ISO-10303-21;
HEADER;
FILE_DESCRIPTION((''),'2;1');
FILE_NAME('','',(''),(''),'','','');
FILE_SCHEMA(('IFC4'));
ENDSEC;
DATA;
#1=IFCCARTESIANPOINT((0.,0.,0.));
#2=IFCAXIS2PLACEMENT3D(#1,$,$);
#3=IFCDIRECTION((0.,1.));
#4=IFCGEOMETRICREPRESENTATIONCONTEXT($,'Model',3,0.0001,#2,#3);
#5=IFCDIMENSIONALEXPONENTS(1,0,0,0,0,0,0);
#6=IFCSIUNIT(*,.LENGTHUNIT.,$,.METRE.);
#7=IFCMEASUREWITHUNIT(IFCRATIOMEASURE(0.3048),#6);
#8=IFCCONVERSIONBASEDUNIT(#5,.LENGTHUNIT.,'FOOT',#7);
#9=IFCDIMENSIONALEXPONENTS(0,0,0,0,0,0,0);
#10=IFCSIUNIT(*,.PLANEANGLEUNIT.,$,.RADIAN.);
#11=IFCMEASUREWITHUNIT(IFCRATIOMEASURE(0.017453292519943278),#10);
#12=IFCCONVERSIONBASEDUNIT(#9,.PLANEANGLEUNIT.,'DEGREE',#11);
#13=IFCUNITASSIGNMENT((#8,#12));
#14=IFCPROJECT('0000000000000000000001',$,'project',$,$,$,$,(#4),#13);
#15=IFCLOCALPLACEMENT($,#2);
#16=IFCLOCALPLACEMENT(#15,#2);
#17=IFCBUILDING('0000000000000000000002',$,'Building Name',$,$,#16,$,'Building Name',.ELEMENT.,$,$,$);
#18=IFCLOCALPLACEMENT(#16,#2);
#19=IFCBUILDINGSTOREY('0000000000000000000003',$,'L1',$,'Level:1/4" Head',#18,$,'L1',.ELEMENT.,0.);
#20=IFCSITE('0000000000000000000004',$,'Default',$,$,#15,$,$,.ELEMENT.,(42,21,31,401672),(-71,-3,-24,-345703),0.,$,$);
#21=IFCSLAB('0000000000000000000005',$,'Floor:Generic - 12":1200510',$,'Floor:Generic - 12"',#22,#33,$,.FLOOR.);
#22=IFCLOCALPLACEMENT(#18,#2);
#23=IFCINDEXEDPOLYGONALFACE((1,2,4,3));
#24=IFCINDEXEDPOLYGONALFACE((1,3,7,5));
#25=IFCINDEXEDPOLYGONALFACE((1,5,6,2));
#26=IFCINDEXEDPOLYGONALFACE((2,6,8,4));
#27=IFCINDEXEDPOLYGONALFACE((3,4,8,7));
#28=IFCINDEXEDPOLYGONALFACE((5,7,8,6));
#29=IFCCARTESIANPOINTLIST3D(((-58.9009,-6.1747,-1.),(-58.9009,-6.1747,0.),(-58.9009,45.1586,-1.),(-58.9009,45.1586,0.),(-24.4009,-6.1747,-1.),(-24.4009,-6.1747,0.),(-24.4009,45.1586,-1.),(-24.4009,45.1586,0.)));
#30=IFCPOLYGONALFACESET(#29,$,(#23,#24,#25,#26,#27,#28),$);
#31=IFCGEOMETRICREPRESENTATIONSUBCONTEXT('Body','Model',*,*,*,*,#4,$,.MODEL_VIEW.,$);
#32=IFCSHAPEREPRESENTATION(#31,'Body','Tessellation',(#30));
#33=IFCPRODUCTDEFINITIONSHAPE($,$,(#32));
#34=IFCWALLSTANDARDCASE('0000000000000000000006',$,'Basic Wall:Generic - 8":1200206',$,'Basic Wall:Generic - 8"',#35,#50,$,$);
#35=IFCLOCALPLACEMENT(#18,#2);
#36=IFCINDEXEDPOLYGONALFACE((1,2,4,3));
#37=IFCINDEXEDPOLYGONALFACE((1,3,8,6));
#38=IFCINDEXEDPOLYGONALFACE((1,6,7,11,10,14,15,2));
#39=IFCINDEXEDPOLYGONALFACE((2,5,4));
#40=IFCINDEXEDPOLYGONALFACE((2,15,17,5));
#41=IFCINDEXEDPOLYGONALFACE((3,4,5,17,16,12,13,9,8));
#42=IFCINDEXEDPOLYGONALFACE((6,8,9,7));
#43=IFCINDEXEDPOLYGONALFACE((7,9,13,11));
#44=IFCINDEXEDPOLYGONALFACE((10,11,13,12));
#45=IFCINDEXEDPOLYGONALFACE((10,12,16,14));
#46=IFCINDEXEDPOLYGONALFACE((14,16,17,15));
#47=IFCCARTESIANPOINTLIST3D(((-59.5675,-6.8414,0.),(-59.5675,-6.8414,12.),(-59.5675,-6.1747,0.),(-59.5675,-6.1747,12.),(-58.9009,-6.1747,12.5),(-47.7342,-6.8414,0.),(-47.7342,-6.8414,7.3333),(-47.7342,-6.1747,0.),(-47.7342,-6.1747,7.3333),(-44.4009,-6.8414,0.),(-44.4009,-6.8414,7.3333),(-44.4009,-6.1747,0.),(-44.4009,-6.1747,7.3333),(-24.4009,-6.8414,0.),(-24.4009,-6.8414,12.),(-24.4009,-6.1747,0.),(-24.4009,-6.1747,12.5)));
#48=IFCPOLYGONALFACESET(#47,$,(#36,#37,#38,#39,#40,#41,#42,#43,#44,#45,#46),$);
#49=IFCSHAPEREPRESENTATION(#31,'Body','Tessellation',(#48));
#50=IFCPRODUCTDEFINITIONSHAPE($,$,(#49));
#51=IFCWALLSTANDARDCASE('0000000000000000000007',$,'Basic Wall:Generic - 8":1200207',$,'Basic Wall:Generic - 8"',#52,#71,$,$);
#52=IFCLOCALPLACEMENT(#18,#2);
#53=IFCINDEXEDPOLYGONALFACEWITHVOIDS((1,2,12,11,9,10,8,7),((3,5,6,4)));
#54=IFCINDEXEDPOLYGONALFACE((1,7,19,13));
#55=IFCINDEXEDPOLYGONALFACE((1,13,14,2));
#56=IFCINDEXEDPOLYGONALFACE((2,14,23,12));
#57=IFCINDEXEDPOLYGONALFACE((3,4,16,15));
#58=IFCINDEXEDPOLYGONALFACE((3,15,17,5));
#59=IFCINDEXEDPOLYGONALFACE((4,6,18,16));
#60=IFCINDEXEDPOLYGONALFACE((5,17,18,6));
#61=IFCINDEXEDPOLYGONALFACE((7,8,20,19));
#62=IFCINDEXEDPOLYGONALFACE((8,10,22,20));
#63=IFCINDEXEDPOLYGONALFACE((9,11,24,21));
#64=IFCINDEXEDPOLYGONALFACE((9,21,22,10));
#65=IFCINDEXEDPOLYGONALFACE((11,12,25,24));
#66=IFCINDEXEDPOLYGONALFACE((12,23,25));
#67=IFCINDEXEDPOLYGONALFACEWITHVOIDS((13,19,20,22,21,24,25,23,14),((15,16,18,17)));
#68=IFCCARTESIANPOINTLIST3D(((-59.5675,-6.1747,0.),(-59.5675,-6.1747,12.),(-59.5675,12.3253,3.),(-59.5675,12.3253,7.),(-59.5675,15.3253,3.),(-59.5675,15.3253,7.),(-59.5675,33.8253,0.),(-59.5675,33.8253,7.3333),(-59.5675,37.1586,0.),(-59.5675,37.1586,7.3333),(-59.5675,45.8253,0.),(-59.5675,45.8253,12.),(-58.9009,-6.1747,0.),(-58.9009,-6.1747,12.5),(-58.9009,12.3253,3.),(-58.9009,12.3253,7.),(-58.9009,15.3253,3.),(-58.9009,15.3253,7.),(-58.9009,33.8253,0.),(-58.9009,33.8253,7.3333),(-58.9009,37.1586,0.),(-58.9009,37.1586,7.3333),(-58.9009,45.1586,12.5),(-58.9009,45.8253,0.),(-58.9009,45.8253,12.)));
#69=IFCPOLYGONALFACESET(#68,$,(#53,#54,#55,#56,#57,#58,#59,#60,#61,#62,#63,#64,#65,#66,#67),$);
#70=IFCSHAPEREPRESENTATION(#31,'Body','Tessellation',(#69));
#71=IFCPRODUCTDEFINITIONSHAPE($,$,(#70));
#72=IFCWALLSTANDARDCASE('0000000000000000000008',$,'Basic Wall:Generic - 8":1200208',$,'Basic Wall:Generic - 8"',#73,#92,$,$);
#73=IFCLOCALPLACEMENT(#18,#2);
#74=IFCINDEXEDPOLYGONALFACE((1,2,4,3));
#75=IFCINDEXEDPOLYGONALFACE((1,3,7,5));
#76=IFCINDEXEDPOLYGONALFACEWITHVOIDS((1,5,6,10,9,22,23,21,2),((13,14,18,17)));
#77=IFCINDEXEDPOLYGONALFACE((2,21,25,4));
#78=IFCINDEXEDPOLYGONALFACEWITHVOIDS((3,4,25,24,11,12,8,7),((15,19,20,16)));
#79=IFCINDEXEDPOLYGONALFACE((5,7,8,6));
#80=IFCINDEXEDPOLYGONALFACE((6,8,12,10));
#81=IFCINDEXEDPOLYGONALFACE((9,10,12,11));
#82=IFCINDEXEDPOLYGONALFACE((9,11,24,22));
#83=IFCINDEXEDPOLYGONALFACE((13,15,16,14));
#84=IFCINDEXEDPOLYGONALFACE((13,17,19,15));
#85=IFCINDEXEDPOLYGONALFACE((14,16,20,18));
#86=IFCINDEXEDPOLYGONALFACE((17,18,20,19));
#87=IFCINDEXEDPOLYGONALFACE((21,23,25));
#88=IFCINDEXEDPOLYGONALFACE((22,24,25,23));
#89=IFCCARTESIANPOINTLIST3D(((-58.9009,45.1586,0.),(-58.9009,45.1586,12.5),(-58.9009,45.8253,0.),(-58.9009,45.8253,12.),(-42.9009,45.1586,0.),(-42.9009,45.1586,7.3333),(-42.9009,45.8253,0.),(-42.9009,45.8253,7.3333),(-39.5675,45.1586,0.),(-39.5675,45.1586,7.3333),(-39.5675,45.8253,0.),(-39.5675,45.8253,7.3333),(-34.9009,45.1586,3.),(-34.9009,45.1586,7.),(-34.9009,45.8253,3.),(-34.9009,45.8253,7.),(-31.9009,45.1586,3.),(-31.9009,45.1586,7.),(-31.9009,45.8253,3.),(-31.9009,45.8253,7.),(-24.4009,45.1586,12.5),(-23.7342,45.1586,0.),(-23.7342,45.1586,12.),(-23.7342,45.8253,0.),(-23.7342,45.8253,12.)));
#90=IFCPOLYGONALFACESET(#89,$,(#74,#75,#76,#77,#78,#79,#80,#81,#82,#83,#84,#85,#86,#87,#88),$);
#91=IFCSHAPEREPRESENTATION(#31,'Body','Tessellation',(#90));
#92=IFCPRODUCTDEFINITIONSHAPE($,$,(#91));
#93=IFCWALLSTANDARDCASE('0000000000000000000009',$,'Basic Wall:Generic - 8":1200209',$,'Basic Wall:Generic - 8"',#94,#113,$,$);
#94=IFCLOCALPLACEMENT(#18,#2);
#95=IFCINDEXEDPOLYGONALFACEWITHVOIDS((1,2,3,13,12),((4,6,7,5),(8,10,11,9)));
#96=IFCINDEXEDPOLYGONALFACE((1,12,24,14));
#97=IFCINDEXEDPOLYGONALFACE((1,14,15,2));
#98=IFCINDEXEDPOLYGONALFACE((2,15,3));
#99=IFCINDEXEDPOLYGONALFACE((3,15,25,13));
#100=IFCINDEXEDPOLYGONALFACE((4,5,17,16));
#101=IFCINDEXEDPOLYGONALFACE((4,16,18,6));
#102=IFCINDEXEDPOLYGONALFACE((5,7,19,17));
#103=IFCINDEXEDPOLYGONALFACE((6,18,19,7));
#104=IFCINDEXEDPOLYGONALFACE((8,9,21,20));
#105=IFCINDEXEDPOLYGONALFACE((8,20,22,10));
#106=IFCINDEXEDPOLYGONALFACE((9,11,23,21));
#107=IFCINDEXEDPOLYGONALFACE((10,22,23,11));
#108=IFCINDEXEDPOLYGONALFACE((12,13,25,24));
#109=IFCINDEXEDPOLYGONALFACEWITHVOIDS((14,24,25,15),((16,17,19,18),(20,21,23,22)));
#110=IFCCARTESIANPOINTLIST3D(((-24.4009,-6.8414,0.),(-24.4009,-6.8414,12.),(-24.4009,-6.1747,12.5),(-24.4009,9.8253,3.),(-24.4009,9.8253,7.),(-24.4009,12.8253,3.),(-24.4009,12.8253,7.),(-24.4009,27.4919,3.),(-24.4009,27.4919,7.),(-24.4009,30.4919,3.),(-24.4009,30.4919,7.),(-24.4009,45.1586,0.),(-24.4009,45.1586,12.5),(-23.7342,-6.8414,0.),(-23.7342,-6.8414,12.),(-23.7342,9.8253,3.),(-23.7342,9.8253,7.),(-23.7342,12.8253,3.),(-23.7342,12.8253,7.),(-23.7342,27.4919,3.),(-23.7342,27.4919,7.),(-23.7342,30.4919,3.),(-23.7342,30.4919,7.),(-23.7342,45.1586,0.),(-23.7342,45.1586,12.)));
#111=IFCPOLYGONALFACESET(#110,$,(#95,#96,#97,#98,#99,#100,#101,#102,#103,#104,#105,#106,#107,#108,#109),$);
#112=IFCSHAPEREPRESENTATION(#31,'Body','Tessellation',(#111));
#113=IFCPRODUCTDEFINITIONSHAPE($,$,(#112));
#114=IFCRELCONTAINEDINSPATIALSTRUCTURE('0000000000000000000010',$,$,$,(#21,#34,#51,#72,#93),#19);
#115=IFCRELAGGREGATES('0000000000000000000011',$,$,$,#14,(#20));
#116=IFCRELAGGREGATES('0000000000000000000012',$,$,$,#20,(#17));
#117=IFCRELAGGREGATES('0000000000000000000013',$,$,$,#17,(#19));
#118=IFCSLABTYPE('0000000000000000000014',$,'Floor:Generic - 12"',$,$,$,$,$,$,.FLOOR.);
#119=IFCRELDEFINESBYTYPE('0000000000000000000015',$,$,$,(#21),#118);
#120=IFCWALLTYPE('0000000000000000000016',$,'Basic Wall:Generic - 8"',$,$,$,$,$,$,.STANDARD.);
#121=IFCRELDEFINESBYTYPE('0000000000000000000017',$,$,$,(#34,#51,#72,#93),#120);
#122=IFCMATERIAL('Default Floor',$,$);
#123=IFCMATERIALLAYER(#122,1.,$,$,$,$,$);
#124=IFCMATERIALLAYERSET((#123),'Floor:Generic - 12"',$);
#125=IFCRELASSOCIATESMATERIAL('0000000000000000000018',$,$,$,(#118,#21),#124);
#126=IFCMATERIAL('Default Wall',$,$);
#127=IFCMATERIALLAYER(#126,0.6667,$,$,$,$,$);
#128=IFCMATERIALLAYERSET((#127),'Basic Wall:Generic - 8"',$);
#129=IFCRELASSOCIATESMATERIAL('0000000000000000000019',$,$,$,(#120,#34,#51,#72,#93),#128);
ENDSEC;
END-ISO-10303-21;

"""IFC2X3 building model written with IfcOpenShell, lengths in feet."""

from ifc_helpers import new_model, entity, si_unit, converted_unit, direction, frame, frame_2d, origin, place, context, subcontext, project, spatial, polyline, rectangle, extrude, clip, bounded_halfspace, material, layer, layer_set, layer_usage, type_object, element, save


model = new_model("IFC2X3")

# Units and contexts
model_context = context("Model", 3, precision=0.0001, world=origin(), true_north=direction((0.0, 1.0)))
body_context = subcontext(model_context, "Body", "Model", "MODEL_VIEW")
ifc_project = project(units=[converted_unit("LENGTHUNIT", "FOOT", entity("IfcRatioMeasure", 0.3048), si_unit("LENGTHUNIT", "METRE"), dimensions=[1, 0, 0, 0, 0, 0, 0]), converted_unit("PLANEANGLEUNIT", "DEGREE", entity("IfcRatioMeasure", 0.017453292519943278), si_unit("PLANEANGLEUNIT", "RADIAN"), dimensions=[0, 0, 0, 0, 0, 0, 0])], contexts=[model_context])

# Site, building, storey
site_placement = place(None, origin())
site = spatial("IfcSite", under=ifc_project, at=site_placement, Name="Default", CompositionType="ELEMENT", RefLatitude=(42, 21, 31, 401672), RefLongitude=(-71, -3, -24, -345703), RefElevation=0.0)
building_placement = place(site_placement, origin())
building = spatial("IfcBuilding", under=site, at=building_placement, Name="Building Name", LongName="Building Name", CompositionType="ELEMENT")
storey_placement = place(building_placement, origin())
storey = spatial("IfcBuildingStorey", under=building, at=storey_placement, Name="L1", ObjectType="Level:1/4\" Head", LongName="L1", CompositionType="ELEMENT", Elevation=0.0)

# Slab
ifc_material_1 = material(Name="Default Floor")
ifc_layer_1 = layer(ifc_material_1, 1.0)
ifc_layer_set_1 = layer_set([ifc_layer_1], Name="Floor:Generic - 12\"")
ifc_layer_usage_1 = layer_usage(ifc_layer_set_1, "AXIS3", "POSITIVE", 0.0)
slab_type = type_object("IfcSlabType", Name="Floor:Generic - 12\"", PredefinedType="FLOOR", material=ifc_layer_set_1)
slab_placement = place(storey_placement, origin())
element("IfcSlab", 1, at=slab_placement, inside=storey, type_object=slab_type, material=ifc_layer_usage_1, Name="Floor:Generic - 12\":1200510", ObjectType="Floor:Generic - 12\"", PredefinedType="FLOOR", context=body_context, shape_type="SweptSolid", body=[
    extrude(rectangle(XDim=51.3333, YDim=34.5, at=frame_2d((0.0, 0.0), x_axis=(1.0, 0.0))), frame((-41.6509, 19.4919, 0.0), z_axis=(0.0, 0.0, -1.0), x_axis=(0.0, 1.0, 0.0)), (0.0, 0.0, 1.0), 1.0),
])

# Wall, opening
ifc_material_2 = material(Name="Default Wall")
ifc_layer_2 = layer(ifc_material_2, 0.6667)
ifc_layer_set_2 = layer_set([ifc_layer_2], Name="Basic Wall:Generic - 8\"")
ifc_layer_usage_2 = layer_usage(ifc_layer_set_2, "AXIS2", "NEGATIVE", 0.3333)
wall_type = type_object("IfcWallType", Name="Basic Wall:Generic - 8\"", PredefinedType="STANDARD", material=ifc_layer_set_2)
wall_1_placement = place(storey_placement, frame((-59.5675, -6.5081, 0.0)))
wall_1 = element("IfcWallStandardCase", 2, at=wall_1_placement, inside=storey, type_object=wall_type, material=ifc_layer_usage_2, Name="Basic Wall:Generic - 8\":1200206", ObjectType="Basic Wall:Generic - 8\"", context=body_context, shape_type="Clipping", body=[
    clip(clip(extrude(rectangle(XDim=0.6667, YDim=35.1667, at=frame_2d((17.5833, 0.0), x_axis=(0.0, 1.0))), origin(), (0.0, 0.0, 1.0), 12.5), bounded_halfspace(frame((0.0, 0.3333, 12.0), z_axis=(-0.6, 0.0, 0.8), x_axis=(0.0, -1.0, 0.0)), False, frame((0.0, 0.3333, 12.0)), polyline([(0.0, 0.0), (0.0, -0.6667), (0.6667, 0.0), (0.0, 0.0)]))), bounded_halfspace(frame((0.0, -0.3333, 12.0), z_axis=(0.0, -0.6, 0.8), x_axis=(1.0, 0.0, 0.0)), False, frame((0.0, -0.3333, 12.0)), polyline([(0.0, 0.0), (35.1667, 0.0), (35.1667, 0.6667), (0.6667, 0.6667), (0.0, 0.0)]))),
])
opening_1_placement = place(wall_1_placement, frame((15.1667, 0.3333, 0.0)))
element("IfcOpeningElement", 3, at=opening_1_placement, cuts=wall_1, ObjectType="Opening", context=body_context, shape_type="SweptSolid", body=[
    extrude(rectangle(XDim=7.3333, YDim=3.3333, at=frame_2d((3.6667, 1.6667), x_axis=(1.0, 0.0))), frame((0.0, 0.0, 0.0), z_axis=(0.0, -1.0, 0.0), x_axis=(0.0, 0.0, 1.0)), (0.0, 0.0, 1.0), 0.6667),
])

# Walls, openings
wall_2_placement = place(storey_placement, frame((-59.2342, 45.8253, 0.0), z_axis=(0.0, 0.0, 1.0), x_axis=(0.0, -1.0, 0.0)))
wall_2 = element("IfcWallStandardCase", 4, at=wall_2_placement, inside=storey, type_object=wall_type, material=ifc_layer_usage_2, Name="Basic Wall:Generic - 8\":1200207", ObjectType="Basic Wall:Generic - 8\"", context=body_context, shape_type="Clipping", body=[
    clip(clip(extrude(rectangle(XDim=52.0, YDim=0.6667, at=frame_2d((26.0, 0.0), x_axis=(-1.0, 0.0))), origin(), (0.0, 0.0, 1.0), 12.5), bounded_halfspace(frame((0.0, -0.3333, 12.0), z_axis=(0.0, -0.6, 0.8), x_axis=(1.0, 0.0, 0.0)), False, frame((0.0, -0.3333, 12.0)), polyline([(0.0, 0.0), (52.0, 0.0), (52.0, 0.6667), (0.6667, 0.6667), (0.0, 0.0)]))), bounded_halfspace(frame((0.0, 0.3333, 12.0), z_axis=(-0.6, 0.0, 0.8), x_axis=(0.0, -1.0, 0.0)), False, frame((0.0, 0.3333, 12.0)), polyline([(0.0, 0.0), (0.0, -0.6667), (0.6667, 0.0), (0.0, 0.0)]))),
])
opening_2_placement = place(wall_2_placement, frame((8.6667, -0.3333, 0.0)))
element("IfcOpeningElement", 5, at=opening_2_placement, cuts=wall_2, ObjectType="Opening", context=body_context, shape_type="SweptSolid", body=[
    extrude(rectangle(XDim=7.3333, YDim=3.3333, at=frame_2d((3.6667, 1.6667), x_axis=(1.0, 0.0))), frame((0.0, 0.0, 0.0), z_axis=(0.0, 1.0, 0.0), x_axis=(0.0, 0.0, 1.0)), (0.0, 0.0, 1.0), 0.6667),
])
opening_3_placement = place(wall_2_placement, frame((30.5, -0.3333, 3.0)))
element("IfcOpeningElement", 6, at=opening_3_placement, cuts=wall_2, ObjectType="Opening", context=body_context, shape_type="SweptSolid", body=[
    extrude(rectangle(XDim=4.0, YDim=3.0, at=frame_2d((2.0, 1.5), x_axis=(-1.0, 0.0))), frame((0.0, 0.0, 0.0), z_axis=(0.0, 1.0, 0.0), x_axis=(0.0, 0.0, 1.0)), (0.0, 0.0, 1.0), 0.6667),
])
wall_3_placement = place(storey_placement, frame((-23.7342, 45.4919, 0.0), z_axis=(0.0, 0.0, 1.0), x_axis=(-1.0, 0.0, 0.0)))
wall_3 = element("IfcWallStandardCase", 7, at=wall_3_placement, inside=storey, type_object=wall_type, material=ifc_layer_usage_2, Name="Basic Wall:Generic - 8\":1200208", ObjectType="Basic Wall:Generic - 8\"", context=body_context, shape_type="Clipping", body=[
    clip(clip(extrude(rectangle(XDim=35.1667, YDim=0.6667, at=frame_2d((17.5833, 0.0), x_axis=(-1.0, 0.0))), origin(), (0.0, 0.0, 1.0), 12.5), bounded_halfspace(frame((0.0, 0.3333, 12.0), z_axis=(-0.6, 0.0, 0.8), x_axis=(0.0, -1.0, 0.0)), False, frame((0.0, 0.3333, 12.0)), polyline([(0.0, 0.0), (0.0, -0.6667), (0.6667, 0.0), (0.0, 0.0)]))), bounded_halfspace(frame((0.0, -0.3333, 12.0), z_axis=(0.0, -0.6, 0.8), x_axis=(1.0, 0.0, 0.0)), False, frame((0.0, -0.3333, 12.0)), polyline([(0.0, 0.0), (35.1667, 0.0), (35.1667, 0.6667), (0.6667, 0.6667), (0.0, 0.0)]))),
])
opening_4_placement = place(wall_3_placement, frame((15.8333, -0.3333, 0.0)))
element("IfcOpeningElement", 8, at=opening_4_placement, cuts=wall_3, ObjectType="Opening", context=body_context, shape_type="SweptSolid", body=[
    extrude(rectangle(XDim=7.3333, YDim=3.3333, at=frame_2d((3.6667, 1.6667), x_axis=(1.0, 0.0))), frame((0.0, 0.0, 0.0), z_axis=(0.0, 1.0, 0.0), x_axis=(0.0, 0.0, 1.0)), (0.0, 0.0, 1.0), 0.6667),
])
opening_5_placement = place(wall_3_placement, frame((8.1667, -0.3333, 3.0)))
element("IfcOpeningElement", 9, at=opening_5_placement, cuts=wall_3, ObjectType="Opening", context=body_context, shape_type="SweptSolid", body=[
    extrude(rectangle(XDim=4.0, YDim=3.0, at=frame_2d((2.0, 1.5), x_axis=(-1.0, 0.0))), frame((0.0, 0.0, 0.0), z_axis=(0.0, 1.0, 0.0), x_axis=(0.0, 0.0, 1.0)), (0.0, 0.0, 1.0), 0.6667),
])
wall_4_placement = place(storey_placement, frame((-24.0675, -6.8414, 0.0), z_axis=(0.0, 0.0, 1.0), x_axis=(0.0, 1.0, 0.0)))
wall_4 = element("IfcWallStandardCase", 10, at=wall_4_placement, inside=storey, type_object=wall_type, material=ifc_layer_usage_2, Name="Basic Wall:Generic - 8\":1200209", ObjectType="Basic Wall:Generic - 8\"", context=body_context, shape_type="Clipping", body=[
    clip(clip(extrude(rectangle(XDim=52.0, YDim=0.6667, at=frame_2d((26.0, 0.0), x_axis=(-1.0, 0.0))), origin(), (0.0, 0.0, 1.0), 12.5), bounded_halfspace(frame((0.6667, 0.3333, 12.5), z_axis=(-0.6, 0.0, 0.8), x_axis=(0.0, -1.0, 0.0)), False, frame((0.6667, 0.3333, 12.5)), polyline([(0.0, 0.0), (-0.6667, 0.0), (-0.6667, -0.6667), (0.0, 0.0)]))), bounded_halfspace(frame((0.0, -0.3333, 12.0), z_axis=(0.0, -0.6, 0.8), x_axis=(1.0, 0.0, 0.0)), False, frame((0.0, -0.3333, 12.0)), polyline([(0.0, 0.0), (52.0, 0.0), (52.0, 0.6667), (0.6667, 0.6667), (0.0, 0.0)]))),
])
opening_6_placement = place(wall_4_placement, frame((19.6667, 0.3333, 3.0)))
element("IfcOpeningElement", 11, at=opening_6_placement, cuts=wall_4, ObjectType="Opening", context=body_context, shape_type="SweptSolid", body=[
    extrude(rectangle(XDim=4.0, YDim=3.0, at=frame_2d((2.0, 1.5), x_axis=(-1.0, 0.0))), frame((0.0, 0.0, 0.0), z_axis=(0.0, -1.0, 0.0), x_axis=(0.0, 0.0, 1.0)), (0.0, 0.0, 1.0), 0.6667),
])
opening_7_placement = place(wall_4_placement, frame((37.3333, 0.3333, 3.0)))
element("IfcOpeningElement", 12, at=opening_7_placement, cuts=wall_4, ObjectType="Opening", context=body_context, shape_type="SweptSolid", body=[
    extrude(rectangle(XDim=4.0, YDim=3.0, at=frame_2d((2.0, 1.5), x_axis=(-1.0, 0.0))), frame((0.0, 0.0, 0.0), z_axis=(0.0, -1.0, 0.0), x_axis=(0.0, 0.0, 1.0)), (0.0, 0.0, 1.0), 0.6667),
])

save(model, "model.ifc")
